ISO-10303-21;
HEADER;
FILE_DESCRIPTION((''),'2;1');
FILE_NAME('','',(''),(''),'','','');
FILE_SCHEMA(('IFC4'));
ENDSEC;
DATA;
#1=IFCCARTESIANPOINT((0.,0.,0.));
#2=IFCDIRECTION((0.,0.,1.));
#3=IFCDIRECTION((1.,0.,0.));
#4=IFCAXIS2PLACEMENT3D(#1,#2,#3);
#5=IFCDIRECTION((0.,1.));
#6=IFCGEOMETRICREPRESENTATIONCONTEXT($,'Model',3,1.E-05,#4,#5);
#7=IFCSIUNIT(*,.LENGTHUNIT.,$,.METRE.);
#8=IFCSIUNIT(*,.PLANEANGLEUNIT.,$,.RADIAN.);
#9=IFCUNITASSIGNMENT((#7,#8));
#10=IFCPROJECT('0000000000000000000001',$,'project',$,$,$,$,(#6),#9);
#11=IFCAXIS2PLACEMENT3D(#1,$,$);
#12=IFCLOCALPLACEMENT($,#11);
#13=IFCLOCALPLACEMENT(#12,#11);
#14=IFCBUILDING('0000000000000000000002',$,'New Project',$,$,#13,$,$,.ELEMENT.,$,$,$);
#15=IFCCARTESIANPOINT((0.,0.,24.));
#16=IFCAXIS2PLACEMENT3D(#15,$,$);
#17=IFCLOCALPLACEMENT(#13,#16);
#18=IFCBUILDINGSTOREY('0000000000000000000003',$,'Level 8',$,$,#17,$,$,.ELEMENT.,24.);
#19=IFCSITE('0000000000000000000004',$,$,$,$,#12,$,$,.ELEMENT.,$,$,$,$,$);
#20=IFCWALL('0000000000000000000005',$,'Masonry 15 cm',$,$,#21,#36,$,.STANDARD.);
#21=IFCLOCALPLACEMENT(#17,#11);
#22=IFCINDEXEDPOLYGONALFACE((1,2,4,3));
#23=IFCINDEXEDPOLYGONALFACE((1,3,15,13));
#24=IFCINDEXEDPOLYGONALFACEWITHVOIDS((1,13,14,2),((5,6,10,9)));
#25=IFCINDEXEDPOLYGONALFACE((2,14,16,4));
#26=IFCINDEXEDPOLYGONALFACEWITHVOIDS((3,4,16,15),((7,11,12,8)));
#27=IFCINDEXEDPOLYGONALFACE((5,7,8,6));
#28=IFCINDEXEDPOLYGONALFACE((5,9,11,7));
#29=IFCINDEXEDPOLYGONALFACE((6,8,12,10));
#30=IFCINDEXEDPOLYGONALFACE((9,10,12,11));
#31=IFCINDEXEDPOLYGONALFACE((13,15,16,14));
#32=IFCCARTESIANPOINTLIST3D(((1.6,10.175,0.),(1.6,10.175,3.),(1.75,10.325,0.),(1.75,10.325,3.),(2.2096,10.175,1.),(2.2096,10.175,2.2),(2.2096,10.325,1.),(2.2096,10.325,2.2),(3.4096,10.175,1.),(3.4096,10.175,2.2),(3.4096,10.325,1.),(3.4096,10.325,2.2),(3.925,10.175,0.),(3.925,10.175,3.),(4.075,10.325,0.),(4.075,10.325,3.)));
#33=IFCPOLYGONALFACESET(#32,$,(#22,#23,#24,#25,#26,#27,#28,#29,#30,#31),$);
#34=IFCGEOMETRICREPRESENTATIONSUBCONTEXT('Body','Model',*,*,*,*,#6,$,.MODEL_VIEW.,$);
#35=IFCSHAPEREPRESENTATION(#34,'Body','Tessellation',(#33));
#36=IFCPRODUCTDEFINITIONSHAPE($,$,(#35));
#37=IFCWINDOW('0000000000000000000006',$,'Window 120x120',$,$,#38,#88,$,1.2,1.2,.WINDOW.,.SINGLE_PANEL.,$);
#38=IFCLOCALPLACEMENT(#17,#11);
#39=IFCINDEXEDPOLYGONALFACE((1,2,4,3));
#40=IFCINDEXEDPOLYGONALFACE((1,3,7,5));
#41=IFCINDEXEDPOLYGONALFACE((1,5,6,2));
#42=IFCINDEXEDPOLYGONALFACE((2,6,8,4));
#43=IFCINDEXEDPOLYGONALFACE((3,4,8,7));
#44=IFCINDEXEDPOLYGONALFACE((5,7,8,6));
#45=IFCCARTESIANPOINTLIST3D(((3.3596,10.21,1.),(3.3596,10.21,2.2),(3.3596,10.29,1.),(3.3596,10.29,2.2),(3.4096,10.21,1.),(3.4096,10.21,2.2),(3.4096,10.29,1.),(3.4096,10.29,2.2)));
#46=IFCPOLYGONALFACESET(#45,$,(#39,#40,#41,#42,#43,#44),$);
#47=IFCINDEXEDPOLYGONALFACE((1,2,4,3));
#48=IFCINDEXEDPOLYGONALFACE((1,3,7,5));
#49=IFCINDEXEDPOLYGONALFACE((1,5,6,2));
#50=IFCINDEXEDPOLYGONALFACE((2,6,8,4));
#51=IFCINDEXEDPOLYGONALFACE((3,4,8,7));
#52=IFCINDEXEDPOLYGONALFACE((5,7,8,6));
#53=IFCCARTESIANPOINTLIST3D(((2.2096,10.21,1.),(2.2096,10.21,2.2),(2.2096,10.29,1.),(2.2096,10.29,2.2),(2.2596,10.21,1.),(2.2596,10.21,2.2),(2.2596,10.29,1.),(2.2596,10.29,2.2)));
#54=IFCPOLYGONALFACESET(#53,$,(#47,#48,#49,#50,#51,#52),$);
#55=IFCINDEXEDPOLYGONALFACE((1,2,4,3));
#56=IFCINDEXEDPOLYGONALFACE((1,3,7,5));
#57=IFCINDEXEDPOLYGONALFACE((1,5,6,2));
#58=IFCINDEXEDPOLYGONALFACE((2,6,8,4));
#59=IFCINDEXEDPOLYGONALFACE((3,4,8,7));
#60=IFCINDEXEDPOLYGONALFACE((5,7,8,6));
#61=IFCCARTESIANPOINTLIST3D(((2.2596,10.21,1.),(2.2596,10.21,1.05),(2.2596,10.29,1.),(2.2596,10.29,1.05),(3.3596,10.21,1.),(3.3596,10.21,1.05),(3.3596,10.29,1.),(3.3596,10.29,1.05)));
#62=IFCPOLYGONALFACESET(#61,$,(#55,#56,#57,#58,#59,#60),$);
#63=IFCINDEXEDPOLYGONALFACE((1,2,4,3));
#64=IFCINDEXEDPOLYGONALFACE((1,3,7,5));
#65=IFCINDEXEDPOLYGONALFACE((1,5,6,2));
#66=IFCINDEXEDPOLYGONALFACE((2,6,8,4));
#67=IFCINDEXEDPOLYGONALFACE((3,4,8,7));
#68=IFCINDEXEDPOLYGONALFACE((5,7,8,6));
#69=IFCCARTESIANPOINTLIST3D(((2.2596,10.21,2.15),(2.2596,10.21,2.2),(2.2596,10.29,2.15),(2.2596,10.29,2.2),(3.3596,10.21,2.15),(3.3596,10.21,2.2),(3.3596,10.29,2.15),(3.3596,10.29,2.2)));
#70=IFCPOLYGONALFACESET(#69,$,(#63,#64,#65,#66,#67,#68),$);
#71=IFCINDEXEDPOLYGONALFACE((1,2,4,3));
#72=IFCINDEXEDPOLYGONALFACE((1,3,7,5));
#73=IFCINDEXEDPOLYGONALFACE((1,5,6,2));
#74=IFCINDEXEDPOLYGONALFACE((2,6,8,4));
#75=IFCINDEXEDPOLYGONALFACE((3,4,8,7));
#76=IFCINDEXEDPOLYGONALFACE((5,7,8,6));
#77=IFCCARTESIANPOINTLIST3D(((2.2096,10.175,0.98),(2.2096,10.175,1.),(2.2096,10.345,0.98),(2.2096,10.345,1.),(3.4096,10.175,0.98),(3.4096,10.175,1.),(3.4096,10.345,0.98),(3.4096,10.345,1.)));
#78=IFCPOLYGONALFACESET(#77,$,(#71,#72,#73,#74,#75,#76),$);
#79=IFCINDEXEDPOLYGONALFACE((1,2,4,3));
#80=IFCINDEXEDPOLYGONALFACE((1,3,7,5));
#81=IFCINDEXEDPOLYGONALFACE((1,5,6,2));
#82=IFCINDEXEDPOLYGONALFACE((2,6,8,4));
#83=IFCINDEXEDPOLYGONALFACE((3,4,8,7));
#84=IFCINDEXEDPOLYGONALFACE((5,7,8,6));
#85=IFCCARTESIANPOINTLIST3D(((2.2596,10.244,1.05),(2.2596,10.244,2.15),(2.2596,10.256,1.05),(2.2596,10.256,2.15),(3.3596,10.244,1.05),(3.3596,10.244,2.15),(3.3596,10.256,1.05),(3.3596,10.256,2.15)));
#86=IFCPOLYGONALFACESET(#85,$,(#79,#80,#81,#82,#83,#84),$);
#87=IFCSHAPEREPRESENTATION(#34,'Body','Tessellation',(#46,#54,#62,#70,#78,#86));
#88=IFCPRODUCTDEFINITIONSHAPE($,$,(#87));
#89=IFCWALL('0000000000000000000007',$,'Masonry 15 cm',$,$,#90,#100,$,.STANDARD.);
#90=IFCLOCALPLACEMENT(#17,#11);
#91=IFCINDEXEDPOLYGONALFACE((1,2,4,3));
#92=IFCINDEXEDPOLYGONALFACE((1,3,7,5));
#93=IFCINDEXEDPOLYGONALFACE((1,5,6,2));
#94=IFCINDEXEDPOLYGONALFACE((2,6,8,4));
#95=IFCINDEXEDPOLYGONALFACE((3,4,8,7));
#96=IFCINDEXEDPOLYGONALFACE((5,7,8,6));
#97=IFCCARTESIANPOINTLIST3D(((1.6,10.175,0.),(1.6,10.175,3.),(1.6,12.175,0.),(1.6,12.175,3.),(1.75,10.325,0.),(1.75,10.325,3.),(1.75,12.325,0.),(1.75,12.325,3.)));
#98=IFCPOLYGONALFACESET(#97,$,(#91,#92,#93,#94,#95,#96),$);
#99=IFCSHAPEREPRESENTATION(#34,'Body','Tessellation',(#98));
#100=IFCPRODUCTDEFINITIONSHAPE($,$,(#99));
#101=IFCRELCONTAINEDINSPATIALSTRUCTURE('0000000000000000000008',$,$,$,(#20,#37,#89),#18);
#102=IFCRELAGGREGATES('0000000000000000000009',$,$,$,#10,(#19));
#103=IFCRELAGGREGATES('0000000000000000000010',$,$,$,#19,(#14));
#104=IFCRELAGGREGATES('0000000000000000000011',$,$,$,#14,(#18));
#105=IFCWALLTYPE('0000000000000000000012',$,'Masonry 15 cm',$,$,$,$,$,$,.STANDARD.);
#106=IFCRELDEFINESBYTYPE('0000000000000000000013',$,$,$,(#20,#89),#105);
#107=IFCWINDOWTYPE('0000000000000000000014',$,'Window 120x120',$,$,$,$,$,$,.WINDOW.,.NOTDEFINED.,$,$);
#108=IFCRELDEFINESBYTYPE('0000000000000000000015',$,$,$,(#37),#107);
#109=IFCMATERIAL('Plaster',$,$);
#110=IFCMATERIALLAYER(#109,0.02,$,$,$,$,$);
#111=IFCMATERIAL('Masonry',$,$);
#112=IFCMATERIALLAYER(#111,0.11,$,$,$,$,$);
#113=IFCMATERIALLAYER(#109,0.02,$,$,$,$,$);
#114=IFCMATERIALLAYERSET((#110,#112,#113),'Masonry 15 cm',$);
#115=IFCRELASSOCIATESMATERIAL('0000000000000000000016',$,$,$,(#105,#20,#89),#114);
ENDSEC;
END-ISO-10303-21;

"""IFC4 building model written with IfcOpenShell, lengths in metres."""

from ifc_helpers import new_model, si_unit, direction, frame, frame_2d, origin, origin_with_axes, place, context, subcontext, project, spatial, polyline, rectangle, outline, extrude, material, layer, layer_set, layer_usage, type_object, element, fill, save


model = new_model("IFC4")

# Units and contexts
model_context = context("Model", 3, precision=1e-05, world=origin_with_axes(), true_north=direction((0.0, 1.0)))
body_context = subcontext(model_context, "Body", "Model", "MODEL_VIEW")
ifc_project = project(units=[si_unit("LENGTHUNIT", "METRE"), si_unit("PLANEANGLEUNIT", "RADIAN")], contexts=[model_context])

# Site, building, storey
site_placement = place(None, origin())
site = spatial("IfcSite", under=ifc_project, at=site_placement, CompositionType="ELEMENT")
building_placement = place(site_placement, origin())
building = spatial("IfcBuilding", under=site, at=building_placement, Name="New Project", CompositionType="ELEMENT")
storey_placement = place(building_placement, frame((0.0, 0.0, 24.0)))
storey = spatial("IfcBuildingStorey", under=building, at=storey_placement, Name="Level 8", CompositionType="ELEMENT", Elevation=24.0)

# Shared definitions
ifc_material_1 = material(Name="Plaster")
ifc_layer_1 = layer(ifc_material_1, 0.02)
ifc_material_2 = material(Name="Masonry")
ifc_layer_2 = layer(ifc_material_2, 0.11)
ifc_layer_3 = layer(ifc_material_1, 0.02)
ifc_layer_set_1 = layer_set([ifc_layer_1, ifc_layer_2, ifc_layer_3], Name="Masonry 15 cm")
ifc_layer_usage_1 = layer_usage(ifc_layer_set_1, "AXIS2", "NEGATIVE", 0.075)
wall_type_1 = type_object("IfcWallType", Name="Masonry 15 cm", PredefinedType="STANDARD", material=ifc_layer_set_1)

# Shared definitions
window_type = type_object("IfcWindowType", Name="Window 120x120", PartitioningType="NOTDEFINED", PredefinedType="WINDOW")

# Wall, opening, window
wall_1_placement = place(storey_placement, frame((1.675, 10.25, 0.0)))
wall_1 = element("IfcWall", 1, at=wall_1_placement, inside=storey, type_object=wall_type_1, material=ifc_layer_usage_1, Name="Masonry 15 cm", PredefinedType="STANDARD", context=body_context, shape_type="SweptSolid", body=[
    extrude(outline(polyline([(-0.075, -0.075), (2.25, -0.075), (2.4, 0.075), (0.075, 0.075), (-0.075, -0.075)])), origin(), (0.0, 0.0, 1.0), 3.0),
])
opening_1_placement = place(wall_1_placement, frame((0.5346, 0.0, 1.0)))
opening_1 = element("IfcOpeningElement", 2, at=opening_1_placement, cuts=wall_1, PredefinedType="OPENING", context=body_context, shape_type="SweptSolid", body=[
    extrude(rectangle(XDim=1.2, YDim=0.25, at=frame_2d((0.6, 0.0))), origin(), (0.0, 0.0, 1.0), 1.2),
])
window_1_placement = place(opening_1_placement, origin())
window_1 = element("IfcWindow", 3, at=window_1_placement, inside=storey, type_object=window_type, Name="Window 120x120", OverallHeight=1.2, OverallWidth=1.2, PartitioningType="SINGLE_PANEL", PredefinedType="WINDOW", context=body_context, shape_type="SweptSolid", body=[
    extrude(outline(polyline([(1.2, 0.04), (1.15, 0.04), (1.15, -0.04), (1.2, -0.04), (1.2, 0.04)])), origin(), (0.0, 0.0, 1.0), 1.2),
    extrude(outline(polyline([(0.05, 0.04), (0.0, 0.04), (0.0, -0.04), (0.05, -0.04), (0.05, 0.04)])), origin(), (0.0, 0.0, 1.0), 1.2),
    extrude(outline(polyline([(1.15, 0.04), (0.05, 0.04), (0.05, -0.04), (1.15, -0.04), (1.15, 0.04)])), origin(), (0.0, 0.0, 1.0), 0.05),
    extrude(outline(polyline([(1.15, 0.04), (0.05, 0.04), (0.05, -0.04), (1.15, -0.04), (1.15, 0.04)])), frame((0.0, 0.0, 1.15)), (0.0, 0.0, 1.0), 0.05),
    extrude(outline(polyline([(1.2, 0.095), (0.0, 0.095), (0.0, -0.075), (1.2, -0.075), (1.2, 0.095)])), frame((0.0, 0.0, -0.02)), (0.0, 0.0, 1.0), 0.02),
    extrude(outline(polyline([(1.15, 0.006), (0.05, 0.006), (0.05, -0.006), (1.15, -0.006), (1.15, 0.006)])), frame((0.0, 0.0, 0.05)), (0.0, 0.0, 1.0), 1.1),
])
fill(opening_1, window_1)

# Wall
wall_2_placement = place(storey_placement, frame((1.675, 12.25, 0.0), z_axis=(0.0, 0.0, 1.0), x_axis=(0.0, -1.0, 0.0)))
element("IfcWall", 4, at=wall_2_placement, inside=storey, type_object=wall_type_1, material=ifc_layer_usage_1, Name="Masonry 15 cm", PredefinedType="STANDARD", context=body_context, shape_type="SweptSolid", body=[
    extrude(outline(polyline([(0.075, -0.075), (2.075, -0.075), (1.925, 0.075), (-0.075, 0.075), (0.075, -0.075)])), origin(), (0.0, 0.0, 1.0), 3.0),
])

save(model, "model.ifc")
